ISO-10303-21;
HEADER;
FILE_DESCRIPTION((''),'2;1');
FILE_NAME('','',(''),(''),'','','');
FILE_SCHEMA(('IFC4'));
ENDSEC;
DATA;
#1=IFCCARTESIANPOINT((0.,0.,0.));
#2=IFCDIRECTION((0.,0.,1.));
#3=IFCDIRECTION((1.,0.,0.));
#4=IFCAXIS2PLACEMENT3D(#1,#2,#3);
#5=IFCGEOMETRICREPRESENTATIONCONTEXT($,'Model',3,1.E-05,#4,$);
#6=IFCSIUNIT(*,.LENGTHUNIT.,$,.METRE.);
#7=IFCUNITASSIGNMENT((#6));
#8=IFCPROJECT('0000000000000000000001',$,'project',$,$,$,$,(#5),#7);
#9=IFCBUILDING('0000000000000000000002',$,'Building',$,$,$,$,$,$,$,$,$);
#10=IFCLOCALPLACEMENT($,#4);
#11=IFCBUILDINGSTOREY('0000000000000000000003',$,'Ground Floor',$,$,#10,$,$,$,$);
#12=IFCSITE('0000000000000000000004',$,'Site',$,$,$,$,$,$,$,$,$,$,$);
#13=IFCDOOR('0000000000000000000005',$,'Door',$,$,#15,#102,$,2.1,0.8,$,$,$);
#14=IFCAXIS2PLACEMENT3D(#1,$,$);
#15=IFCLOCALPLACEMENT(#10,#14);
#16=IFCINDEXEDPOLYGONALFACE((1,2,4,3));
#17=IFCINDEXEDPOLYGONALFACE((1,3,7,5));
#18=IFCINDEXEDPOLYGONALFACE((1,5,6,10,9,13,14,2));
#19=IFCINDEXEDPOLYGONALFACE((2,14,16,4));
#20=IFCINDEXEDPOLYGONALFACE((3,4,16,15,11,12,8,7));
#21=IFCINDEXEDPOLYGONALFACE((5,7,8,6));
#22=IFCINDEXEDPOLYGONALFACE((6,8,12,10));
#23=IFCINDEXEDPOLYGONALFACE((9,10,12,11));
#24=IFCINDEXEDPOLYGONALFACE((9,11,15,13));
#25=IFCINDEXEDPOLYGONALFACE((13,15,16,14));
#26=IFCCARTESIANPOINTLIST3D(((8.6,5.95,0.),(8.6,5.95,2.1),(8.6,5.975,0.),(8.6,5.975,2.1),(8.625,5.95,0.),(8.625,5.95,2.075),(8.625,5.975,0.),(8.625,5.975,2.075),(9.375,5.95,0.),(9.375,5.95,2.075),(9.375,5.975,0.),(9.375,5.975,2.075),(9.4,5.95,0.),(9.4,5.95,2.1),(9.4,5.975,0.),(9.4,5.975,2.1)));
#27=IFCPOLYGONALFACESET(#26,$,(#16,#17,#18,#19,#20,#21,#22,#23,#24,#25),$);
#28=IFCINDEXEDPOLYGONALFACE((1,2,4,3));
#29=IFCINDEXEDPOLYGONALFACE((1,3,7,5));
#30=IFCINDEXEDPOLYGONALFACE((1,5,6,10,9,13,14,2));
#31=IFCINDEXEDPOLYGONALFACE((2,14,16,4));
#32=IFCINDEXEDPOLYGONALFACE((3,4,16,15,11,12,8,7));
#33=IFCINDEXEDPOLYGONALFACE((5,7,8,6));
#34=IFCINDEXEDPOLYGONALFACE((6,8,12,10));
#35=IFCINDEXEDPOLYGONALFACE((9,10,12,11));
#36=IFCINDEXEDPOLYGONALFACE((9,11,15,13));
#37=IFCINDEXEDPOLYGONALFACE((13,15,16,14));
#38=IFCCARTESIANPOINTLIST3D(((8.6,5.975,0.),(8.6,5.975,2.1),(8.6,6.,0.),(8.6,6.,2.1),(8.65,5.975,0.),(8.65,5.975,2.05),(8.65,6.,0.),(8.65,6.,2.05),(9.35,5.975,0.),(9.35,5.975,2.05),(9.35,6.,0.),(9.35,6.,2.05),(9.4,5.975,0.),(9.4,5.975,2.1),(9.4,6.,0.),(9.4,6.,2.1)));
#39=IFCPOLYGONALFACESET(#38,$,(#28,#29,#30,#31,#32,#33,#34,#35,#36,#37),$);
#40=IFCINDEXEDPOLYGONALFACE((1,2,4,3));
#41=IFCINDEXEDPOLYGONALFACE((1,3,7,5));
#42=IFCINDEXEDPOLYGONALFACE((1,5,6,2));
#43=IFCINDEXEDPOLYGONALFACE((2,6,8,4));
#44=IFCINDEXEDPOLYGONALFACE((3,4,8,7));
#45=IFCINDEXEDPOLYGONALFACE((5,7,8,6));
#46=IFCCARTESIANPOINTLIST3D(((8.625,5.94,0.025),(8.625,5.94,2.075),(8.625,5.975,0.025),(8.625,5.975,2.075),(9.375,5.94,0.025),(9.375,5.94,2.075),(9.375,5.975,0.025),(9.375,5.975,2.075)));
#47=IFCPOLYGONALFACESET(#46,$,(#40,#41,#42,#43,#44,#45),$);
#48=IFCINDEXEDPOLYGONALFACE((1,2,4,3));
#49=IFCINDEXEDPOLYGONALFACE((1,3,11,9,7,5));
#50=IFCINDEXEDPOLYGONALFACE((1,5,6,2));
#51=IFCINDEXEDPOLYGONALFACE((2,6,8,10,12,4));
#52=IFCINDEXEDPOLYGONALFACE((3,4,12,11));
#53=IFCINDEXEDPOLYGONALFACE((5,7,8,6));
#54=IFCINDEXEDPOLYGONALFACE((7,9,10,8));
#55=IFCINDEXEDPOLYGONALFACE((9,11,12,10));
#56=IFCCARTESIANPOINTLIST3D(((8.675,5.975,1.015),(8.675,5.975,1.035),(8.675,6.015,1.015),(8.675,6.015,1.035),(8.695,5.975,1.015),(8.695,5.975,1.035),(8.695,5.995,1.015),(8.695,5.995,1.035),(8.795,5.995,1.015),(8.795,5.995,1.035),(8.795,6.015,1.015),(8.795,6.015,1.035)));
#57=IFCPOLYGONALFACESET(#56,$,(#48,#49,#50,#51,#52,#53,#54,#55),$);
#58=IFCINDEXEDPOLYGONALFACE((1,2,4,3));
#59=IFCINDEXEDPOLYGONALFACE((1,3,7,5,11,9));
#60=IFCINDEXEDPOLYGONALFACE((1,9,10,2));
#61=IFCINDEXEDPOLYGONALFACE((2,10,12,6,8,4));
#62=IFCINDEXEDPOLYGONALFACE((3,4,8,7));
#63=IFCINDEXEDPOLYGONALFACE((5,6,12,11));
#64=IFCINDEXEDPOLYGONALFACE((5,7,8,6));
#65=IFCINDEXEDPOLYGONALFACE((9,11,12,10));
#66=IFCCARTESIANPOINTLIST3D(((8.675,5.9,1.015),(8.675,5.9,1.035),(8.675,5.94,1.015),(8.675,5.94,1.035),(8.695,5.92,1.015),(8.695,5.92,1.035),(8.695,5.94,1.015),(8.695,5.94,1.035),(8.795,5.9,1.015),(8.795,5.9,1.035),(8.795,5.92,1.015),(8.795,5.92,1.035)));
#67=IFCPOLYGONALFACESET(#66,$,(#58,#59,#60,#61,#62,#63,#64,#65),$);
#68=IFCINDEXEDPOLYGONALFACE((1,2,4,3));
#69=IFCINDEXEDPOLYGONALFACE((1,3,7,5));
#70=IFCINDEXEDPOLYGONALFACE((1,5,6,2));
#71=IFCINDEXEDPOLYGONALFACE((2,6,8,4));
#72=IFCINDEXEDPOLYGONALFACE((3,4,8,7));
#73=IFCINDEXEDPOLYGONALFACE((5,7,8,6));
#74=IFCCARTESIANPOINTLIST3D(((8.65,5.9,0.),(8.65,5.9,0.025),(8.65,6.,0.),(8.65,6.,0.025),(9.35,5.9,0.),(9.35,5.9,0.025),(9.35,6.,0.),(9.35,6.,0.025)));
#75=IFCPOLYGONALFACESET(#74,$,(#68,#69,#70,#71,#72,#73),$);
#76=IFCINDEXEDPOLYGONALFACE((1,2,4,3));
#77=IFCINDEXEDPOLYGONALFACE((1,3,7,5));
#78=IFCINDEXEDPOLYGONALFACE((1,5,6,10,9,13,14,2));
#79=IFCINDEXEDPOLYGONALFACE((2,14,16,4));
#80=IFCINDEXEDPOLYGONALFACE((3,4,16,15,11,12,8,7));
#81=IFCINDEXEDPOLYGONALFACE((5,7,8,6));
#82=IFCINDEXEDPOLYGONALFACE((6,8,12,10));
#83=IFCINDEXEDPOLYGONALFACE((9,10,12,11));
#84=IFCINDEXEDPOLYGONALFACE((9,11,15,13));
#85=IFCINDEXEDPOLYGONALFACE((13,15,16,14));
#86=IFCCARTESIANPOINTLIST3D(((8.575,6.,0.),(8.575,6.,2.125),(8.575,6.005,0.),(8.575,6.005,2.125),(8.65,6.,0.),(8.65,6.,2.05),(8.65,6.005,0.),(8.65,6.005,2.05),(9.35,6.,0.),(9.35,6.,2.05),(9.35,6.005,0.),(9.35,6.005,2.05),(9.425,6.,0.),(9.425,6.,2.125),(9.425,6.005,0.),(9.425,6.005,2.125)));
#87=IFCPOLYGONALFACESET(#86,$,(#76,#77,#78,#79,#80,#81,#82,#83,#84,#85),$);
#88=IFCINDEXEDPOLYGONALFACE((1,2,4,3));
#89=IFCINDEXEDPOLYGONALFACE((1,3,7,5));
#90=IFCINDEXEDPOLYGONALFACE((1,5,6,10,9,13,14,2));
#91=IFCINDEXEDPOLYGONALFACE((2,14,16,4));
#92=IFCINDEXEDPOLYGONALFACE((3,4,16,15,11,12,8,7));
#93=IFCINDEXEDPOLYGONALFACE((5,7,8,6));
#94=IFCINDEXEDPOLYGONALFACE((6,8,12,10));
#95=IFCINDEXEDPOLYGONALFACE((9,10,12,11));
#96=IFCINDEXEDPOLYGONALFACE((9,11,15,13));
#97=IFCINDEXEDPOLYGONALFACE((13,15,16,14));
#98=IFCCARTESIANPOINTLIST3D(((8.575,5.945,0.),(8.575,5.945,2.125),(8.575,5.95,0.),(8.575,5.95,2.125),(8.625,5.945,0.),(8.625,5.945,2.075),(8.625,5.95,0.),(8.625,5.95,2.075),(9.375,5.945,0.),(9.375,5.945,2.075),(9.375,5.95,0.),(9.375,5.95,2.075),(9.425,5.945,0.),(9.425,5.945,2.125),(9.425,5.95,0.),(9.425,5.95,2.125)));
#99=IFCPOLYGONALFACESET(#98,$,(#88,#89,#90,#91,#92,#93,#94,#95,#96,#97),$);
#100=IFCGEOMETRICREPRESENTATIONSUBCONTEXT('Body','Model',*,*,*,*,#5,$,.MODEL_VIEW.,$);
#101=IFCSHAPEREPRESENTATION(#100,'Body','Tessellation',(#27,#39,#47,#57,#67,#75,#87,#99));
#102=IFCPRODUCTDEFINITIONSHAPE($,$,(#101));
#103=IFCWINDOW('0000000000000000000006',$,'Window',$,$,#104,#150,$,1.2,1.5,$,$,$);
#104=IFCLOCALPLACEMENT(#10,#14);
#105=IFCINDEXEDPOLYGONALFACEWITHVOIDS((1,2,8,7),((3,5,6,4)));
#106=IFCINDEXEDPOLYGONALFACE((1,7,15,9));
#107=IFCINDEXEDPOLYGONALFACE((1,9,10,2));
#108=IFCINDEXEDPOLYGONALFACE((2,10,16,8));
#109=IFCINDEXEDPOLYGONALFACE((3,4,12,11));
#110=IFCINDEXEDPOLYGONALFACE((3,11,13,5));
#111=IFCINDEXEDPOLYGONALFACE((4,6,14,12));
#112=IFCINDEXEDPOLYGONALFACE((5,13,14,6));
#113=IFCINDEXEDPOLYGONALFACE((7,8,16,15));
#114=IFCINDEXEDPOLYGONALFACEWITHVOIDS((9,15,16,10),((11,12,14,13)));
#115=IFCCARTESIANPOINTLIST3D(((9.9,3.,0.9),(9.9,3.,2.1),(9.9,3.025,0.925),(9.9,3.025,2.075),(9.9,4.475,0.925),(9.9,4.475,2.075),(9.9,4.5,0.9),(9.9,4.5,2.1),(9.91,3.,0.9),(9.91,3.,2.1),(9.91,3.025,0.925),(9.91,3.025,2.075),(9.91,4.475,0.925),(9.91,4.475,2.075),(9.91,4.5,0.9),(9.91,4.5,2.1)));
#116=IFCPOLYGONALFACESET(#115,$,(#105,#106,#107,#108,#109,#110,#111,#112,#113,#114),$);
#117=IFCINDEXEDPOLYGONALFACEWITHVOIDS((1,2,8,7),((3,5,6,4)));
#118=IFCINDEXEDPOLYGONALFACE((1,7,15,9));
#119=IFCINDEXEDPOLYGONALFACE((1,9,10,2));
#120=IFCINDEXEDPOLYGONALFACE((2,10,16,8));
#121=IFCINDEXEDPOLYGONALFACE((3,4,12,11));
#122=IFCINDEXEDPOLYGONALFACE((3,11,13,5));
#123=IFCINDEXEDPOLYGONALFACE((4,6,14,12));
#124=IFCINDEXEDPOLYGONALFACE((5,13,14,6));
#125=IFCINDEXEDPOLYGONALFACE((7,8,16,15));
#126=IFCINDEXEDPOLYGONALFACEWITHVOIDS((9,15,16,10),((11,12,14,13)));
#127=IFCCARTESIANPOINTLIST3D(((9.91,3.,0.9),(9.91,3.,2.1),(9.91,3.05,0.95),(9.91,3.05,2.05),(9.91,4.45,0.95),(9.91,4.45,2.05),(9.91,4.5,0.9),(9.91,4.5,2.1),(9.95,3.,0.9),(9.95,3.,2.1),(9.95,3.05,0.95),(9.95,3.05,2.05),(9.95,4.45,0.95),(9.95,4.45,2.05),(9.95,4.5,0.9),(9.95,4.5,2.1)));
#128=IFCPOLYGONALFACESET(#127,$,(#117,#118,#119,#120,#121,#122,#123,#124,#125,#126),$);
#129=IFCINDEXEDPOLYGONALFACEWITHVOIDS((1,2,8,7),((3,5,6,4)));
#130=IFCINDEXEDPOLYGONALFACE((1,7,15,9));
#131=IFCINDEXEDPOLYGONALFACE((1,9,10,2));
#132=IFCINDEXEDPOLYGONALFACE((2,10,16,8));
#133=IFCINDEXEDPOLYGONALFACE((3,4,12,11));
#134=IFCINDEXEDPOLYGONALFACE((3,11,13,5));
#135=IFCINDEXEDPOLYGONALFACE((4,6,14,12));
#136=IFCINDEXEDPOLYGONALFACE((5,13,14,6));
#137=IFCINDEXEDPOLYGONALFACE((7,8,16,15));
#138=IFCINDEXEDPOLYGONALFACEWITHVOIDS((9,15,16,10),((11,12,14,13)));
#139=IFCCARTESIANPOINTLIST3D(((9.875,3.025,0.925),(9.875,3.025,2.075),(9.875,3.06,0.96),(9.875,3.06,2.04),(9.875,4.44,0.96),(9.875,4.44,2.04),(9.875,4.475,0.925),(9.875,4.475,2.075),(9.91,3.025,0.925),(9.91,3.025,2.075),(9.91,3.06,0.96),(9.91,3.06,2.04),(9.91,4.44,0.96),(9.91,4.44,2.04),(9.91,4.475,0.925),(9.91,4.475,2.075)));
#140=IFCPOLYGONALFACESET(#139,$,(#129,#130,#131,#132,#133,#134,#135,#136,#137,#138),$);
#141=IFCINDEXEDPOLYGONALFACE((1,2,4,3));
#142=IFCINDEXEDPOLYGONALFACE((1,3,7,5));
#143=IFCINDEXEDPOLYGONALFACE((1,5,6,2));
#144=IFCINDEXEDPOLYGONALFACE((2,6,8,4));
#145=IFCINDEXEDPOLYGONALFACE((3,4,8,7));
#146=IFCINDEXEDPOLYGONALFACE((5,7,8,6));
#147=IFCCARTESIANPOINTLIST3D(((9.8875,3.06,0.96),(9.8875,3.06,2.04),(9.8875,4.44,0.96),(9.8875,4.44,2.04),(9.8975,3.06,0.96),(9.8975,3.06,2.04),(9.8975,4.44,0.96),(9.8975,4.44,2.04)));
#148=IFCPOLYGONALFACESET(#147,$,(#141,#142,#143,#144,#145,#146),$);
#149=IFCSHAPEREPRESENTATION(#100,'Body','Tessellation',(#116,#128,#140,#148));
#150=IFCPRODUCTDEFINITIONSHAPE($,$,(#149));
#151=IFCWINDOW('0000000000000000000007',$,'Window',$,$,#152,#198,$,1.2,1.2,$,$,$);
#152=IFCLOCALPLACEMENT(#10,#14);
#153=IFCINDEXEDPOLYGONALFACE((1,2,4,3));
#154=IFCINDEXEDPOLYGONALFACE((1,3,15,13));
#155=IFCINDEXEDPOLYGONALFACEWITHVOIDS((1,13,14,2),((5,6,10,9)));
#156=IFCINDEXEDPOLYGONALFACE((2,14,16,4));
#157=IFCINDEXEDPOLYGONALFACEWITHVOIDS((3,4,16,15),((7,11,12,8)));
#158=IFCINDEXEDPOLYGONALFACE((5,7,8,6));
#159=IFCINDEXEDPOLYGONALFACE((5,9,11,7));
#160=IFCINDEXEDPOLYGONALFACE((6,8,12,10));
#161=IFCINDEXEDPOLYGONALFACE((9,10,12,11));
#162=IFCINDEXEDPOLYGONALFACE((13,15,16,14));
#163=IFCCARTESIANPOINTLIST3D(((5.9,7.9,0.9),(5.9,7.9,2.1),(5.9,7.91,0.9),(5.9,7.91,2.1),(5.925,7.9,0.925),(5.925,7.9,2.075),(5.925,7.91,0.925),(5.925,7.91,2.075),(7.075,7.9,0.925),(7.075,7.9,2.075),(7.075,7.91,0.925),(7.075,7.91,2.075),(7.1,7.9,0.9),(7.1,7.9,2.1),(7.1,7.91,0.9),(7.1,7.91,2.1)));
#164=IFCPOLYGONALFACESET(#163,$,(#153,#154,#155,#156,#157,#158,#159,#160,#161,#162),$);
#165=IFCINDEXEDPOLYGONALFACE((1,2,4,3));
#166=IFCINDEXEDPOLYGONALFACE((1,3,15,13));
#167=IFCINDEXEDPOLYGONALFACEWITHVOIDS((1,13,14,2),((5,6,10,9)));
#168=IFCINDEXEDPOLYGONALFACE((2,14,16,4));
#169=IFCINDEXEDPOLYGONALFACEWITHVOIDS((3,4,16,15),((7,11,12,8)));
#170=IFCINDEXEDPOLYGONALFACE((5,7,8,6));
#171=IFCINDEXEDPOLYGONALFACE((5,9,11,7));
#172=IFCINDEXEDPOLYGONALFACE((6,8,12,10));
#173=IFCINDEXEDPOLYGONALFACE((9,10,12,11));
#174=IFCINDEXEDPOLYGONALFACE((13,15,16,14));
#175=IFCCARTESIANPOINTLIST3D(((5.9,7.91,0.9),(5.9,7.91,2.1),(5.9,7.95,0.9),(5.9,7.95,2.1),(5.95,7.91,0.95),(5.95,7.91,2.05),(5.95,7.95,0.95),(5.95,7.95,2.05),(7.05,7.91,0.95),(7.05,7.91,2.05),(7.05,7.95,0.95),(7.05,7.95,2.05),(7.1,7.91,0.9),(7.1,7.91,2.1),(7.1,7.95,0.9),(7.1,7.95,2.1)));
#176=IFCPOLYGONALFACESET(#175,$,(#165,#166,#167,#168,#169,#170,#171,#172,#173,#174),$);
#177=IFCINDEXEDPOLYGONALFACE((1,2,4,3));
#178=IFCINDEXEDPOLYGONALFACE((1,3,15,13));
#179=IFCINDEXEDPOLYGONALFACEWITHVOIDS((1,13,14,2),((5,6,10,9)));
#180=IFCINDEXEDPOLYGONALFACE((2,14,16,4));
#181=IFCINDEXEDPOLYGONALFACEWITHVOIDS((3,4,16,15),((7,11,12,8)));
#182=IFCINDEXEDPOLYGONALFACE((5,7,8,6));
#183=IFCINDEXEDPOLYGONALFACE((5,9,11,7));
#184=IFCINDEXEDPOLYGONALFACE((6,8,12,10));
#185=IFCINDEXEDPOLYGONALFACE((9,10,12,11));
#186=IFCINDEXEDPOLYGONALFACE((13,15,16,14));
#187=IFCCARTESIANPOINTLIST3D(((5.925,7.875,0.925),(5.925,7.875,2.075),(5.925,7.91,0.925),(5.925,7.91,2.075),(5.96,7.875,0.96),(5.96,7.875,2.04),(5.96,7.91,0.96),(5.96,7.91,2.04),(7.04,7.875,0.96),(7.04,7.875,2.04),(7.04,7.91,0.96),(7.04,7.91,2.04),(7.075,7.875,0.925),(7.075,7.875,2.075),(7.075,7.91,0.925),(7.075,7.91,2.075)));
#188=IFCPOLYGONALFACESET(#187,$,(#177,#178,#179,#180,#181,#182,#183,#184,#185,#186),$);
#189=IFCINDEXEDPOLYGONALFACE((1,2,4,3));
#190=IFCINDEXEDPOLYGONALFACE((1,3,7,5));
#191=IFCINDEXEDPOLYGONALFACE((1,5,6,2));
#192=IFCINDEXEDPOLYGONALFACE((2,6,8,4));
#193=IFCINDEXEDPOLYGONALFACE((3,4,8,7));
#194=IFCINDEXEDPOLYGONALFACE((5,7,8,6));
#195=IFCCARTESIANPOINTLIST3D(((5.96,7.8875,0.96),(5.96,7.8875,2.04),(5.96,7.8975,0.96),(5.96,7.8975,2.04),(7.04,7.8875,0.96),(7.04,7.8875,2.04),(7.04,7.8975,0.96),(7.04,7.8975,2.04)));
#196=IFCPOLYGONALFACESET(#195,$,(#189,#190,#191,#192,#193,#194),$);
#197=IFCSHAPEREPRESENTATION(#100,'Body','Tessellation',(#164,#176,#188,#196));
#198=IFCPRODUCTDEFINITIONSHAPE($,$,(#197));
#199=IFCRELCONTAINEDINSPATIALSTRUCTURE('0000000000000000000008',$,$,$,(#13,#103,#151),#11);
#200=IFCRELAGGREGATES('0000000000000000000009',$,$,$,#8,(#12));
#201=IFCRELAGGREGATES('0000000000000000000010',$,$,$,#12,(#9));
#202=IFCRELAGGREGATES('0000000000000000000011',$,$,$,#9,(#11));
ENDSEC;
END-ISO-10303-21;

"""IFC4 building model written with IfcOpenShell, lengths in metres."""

from ifc_helpers import new_model, si_unit, frame, origin_with_axes, place, context, subcontext, project, spatial, line, indexed_curve, outline, extrude, element, save


model = new_model("IFC4")

# Units and contexts
model_context = context("Model", 3, precision=1e-05, world=origin_with_axes())
body_context = subcontext(model_context, "Body", "Model", "MODEL_VIEW")
ifc_project = project(units=[si_unit("LENGTHUNIT", "METRE")], contexts=[model_context])

# Site, building, storey
site = spatial("IfcSite", under=ifc_project, Name="Site")
building = spatial("IfcBuilding", under=site, Name="Building")
storey_placement = place(None, origin_with_axes())
storey = spatial("IfcBuildingStorey", under=building, at=storey_placement, Name="Ground Floor")

# Door
door_1_placement = place(storey_placement, frame((9.4, 6.0, 0.0), z_axis=(0.0, 0.0, 1.0), x_axis=(-1.0, 0.0, 0.0)))
element("IfcDoor", 1, at=door_1_placement, inside=storey, Name="Door", OverallHeight=2.1, OverallWidth=0.8, context=body_context, shape_type="SweptSolid", body=[
    extrude(outline(indexed_curve([(0.0, 0.0), (0.0, 2.1), (0.8, 2.1), (0.8, 0.0), (0.775, 0.0), (0.775, 2.075), (0.025, 2.075), (0.025, 0.0)], segments=[line(1, 2, 3, 4, 5, 6, 7, 8, 1)])), frame((0.0, 0.025, 0.0), z_axis=(0.0, -1.0, 0.0), x_axis=(1.0, 0.0, 0.0)), (0.0, 0.0, -1.0), 0.025),
    extrude(outline(indexed_curve([(0.0, 0.0), (0.0, 2.1), (0.8, 2.1), (0.8, 0.0), (0.75, 0.0), (0.75, 2.05), (0.05, 2.05), (0.05, 0.0)], segments=[line(1, 2, 3, 4, 5, 6, 7, 8, 1)])), frame((0.0, 0.0, 0.0), z_axis=(0.0, -1.0, 0.0), x_axis=(1.0, 0.0, 0.0)), (0.0, 0.0, -1.0), 0.025),
    extrude(outline(indexed_curve([(0.0, 0.0), (0.75, 0.0), (0.75, 0.035), (0.0, 0.035)], segments=[line(1, 2, 3, 4, 1)])), frame((0.025, 0.025, 0.025), z_axis=(0.0, 0.0, 1.0), x_axis=(1.0, 0.0, 0.0)), (0.0, 0.0, 1.0), 2.05),
    extrude(outline(indexed_curve([(0.0, 0.0), (0.0, -0.04), (-0.12, -0.04), (-0.12, -0.02), (-0.02, -0.02), (-0.02, 0.0)], segments=[line(1, 2, 3, 4, 5, 6, 1)])), frame((0.725, 0.025, 1.015), z_axis=(0.0, 0.0, 1.0), x_axis=(1.0, 0.0, 0.0)), (0.0, 0.0, 1.0), 0.02),
    extrude(outline(indexed_curve([(0.0, 0.0), (0.0, 0.04), (-0.12, 0.04), (-0.12, 0.02), (-0.02, 0.02), (-0.02, 0.0)], segments=[line(1, 2, 3, 4, 5, 6, 1)])), frame((0.725, 0.06, 1.015), z_axis=(0.0, 0.0, 1.0), x_axis=(1.0, 0.0, 0.0)), (0.0, 0.0, 1.0), 0.02),
    extrude(outline(indexed_curve([(0.0, 0.0), (0.7, 0.0), (0.7, 0.1), (0.0, 0.1)], segments=[line(1, 2, 3, 4, 1)])), frame((0.05, 0.0, 0.0), z_axis=(0.0, 0.0, 1.0), x_axis=(1.0, 0.0, 0.0)), (0.0, 0.0, 1.0), 0.025),
    extrude(outline(indexed_curve([(0.0, 0.0), (0.0, 2.125), (0.85, 2.125), (0.85, 0.0), (0.775, 0.0), (0.775, 2.05), (0.075, 2.05), (0.075, 0.0)], segments=[line(1, 2, 3, 4, 5, 6, 7, 8, 1)])), frame((-0.025, -0.005, 0.0), z_axis=(0.0, -1.0, 0.0), x_axis=(1.0, 0.0, 0.0)), (0.0, 0.0, -1.0), 0.005),
    extrude(outline(indexed_curve([(0.0, 0.0), (0.0, 2.125), (0.85, 2.125), (0.85, 0.0), (0.8, 0.0), (0.8, 2.075), (0.05, 2.075), (0.05, 0.0)], segments=[line(1, 2, 3, 4, 5, 6, 7, 8, 1)])), frame((-0.025, 0.05, 0.0), z_axis=(0.0, -1.0, 0.0), x_axis=(1.0, 0.0, 0.0)), (0.0, 0.0, -1.0), 0.005),
])

# Windows
window_1_placement = place(storey_placement, frame((10.0, 3.0, 0.9), z_axis=(0.0, 0.0, 1.0), x_axis=(0.0, 1.0, 0.0)))
element("IfcWindow", 2, at=window_1_placement, inside=storey, Name="Window", OverallHeight=1.2, OverallWidth=1.5, context=body_context, shape_type="SweptSolid", body=[
    extrude(outline(indexed_curve([(0.0, 0.0), (1.5, 0.0), (1.5, 1.2), (0.0, 1.2)], segments=[line(1, 2, 3, 4, 1)]), holes=[indexed_curve([(0.025, 0.025), (1.475, 0.025), (1.475, 1.175), (0.025, 1.175)], segments=[line(1, 2, 3, 4, 1)])]), frame((0.0, 0.09, 0.0), z_axis=(0.0, -1.0, 0.0), x_axis=(1.0, 0.0, 0.0)), (0.0, 0.0, -1.0), 0.01),
    extrude(outline(indexed_curve([(0.0, 0.0), (1.5, 0.0), (1.5, 1.2), (0.0, 1.2)], segments=[line(1, 2, 3, 4, 1)]), holes=[indexed_curve([(0.05, 0.05), (1.45, 0.05), (1.45, 1.15), (0.05, 1.15)], segments=[line(1, 2, 3, 4, 1)])]), frame((0.0, 0.05, 0.0), z_axis=(0.0, -1.0, 0.0), x_axis=(1.0, 0.0, 0.0)), (0.0, 0.0, -1.0), 0.04),
    extrude(outline(indexed_curve([(0.0, 0.0), (1.45, 0.0), (1.45, 1.15), (0.0, 1.15)], segments=[line(1, 2, 3, 4, 1)]), holes=[indexed_curve([(0.035, 0.035), (1.415, 0.035), (1.415, 1.115), (0.035, 1.115)], segments=[line(1, 2, 3, 4, 1)])]), frame((0.025, 0.09, 0.025), z_axis=(0.0, -1.0, 0.0), x_axis=(1.0, 0.0, 0.0)), (0.0, 0.0, -1.0), 0.035),
    extrude(outline(indexed_curve([(0.035, 0.035), (1.415, 0.035), (1.415, 1.115), (0.035, 1.115)], segments=[line(1, 2, 3, 4, 1)])), frame((0.025, 0.1025, 0.025), z_axis=(0.0, -1.0, 0.0), x_axis=(1.0, 0.0, 0.0)), (0.0, 0.0, -1.0), 0.01),
])
window_2_placement = place(storey_placement, frame((7.1, 8.0, 0.9), z_axis=(0.0, 0.0, 1.0), x_axis=(-1.0, 0.0, 0.0)))
element("IfcWindow", 3, at=window_2_placement, inside=storey, Name="Window", OverallHeight=1.2, OverallWidth=1.2, context=body_context, shape_type="SweptSolid", body=[
    extrude(outline(indexed_curve([(0.0, 0.0), (1.2, 0.0), (1.2, 1.2), (0.0, 1.2)], segments=[line(1, 2, 3, 4, 1)]), holes=[indexed_curve([(0.025, 0.025), (1.175, 0.025), (1.175, 1.175), (0.025, 1.175)], segments=[line(1, 2, 3, 4, 1)])]), frame((0.0, 0.09, 0.0), z_axis=(0.0, -1.0, 0.0), x_axis=(1.0, 0.0, 0.0)), (0.0, 0.0, -1.0), 0.01),
    extrude(outline(indexed_curve([(0.0, 0.0), (1.2, 0.0), (1.2, 1.2), (0.0, 1.2)], segments=[line(1, 2, 3, 4, 1)]), holes=[indexed_curve([(0.05, 0.05), (1.15, 0.05), (1.15, 1.15), (0.05, 1.15)], segments=[line(1, 2, 3, 4, 1)])]), frame((0.0, 0.05, 0.0), z_axis=(0.0, -1.0, 0.0), x_axis=(1.0, 0.0, 0.0)), (0.0, 0.0, -1.0), 0.04),
    extrude(outline(indexed_curve([(0.0, 0.0), (1.15, 0.0), (1.15, 1.15), (0.0, 1.15)], segments=[line(1, 2, 3, 4, 1)]), holes=[indexed_curve([(0.035, 0.035), (1.115, 0.035), (1.115, 1.115), (0.035, 1.115)], segments=[line(1, 2, 3, 4, 1)])]), frame((0.025, 0.09, 0.025), z_axis=(0.0, -1.0, 0.0), x_axis=(1.0, 0.0, 0.0)), (0.0, 0.0, -1.0), 0.035),
    extrude(outline(indexed_curve([(0.035, 0.035), (1.115, 0.035), (1.115, 1.115), (0.035, 1.115)], segments=[line(1, 2, 3, 4, 1)])), frame((0.025, 0.1025, 0.025), z_axis=(0.0, -1.0, 0.0), x_axis=(1.0, 0.0, 0.0)), (0.0, 0.0, -1.0), 0.01),
])

save(model, "model.ifc")
